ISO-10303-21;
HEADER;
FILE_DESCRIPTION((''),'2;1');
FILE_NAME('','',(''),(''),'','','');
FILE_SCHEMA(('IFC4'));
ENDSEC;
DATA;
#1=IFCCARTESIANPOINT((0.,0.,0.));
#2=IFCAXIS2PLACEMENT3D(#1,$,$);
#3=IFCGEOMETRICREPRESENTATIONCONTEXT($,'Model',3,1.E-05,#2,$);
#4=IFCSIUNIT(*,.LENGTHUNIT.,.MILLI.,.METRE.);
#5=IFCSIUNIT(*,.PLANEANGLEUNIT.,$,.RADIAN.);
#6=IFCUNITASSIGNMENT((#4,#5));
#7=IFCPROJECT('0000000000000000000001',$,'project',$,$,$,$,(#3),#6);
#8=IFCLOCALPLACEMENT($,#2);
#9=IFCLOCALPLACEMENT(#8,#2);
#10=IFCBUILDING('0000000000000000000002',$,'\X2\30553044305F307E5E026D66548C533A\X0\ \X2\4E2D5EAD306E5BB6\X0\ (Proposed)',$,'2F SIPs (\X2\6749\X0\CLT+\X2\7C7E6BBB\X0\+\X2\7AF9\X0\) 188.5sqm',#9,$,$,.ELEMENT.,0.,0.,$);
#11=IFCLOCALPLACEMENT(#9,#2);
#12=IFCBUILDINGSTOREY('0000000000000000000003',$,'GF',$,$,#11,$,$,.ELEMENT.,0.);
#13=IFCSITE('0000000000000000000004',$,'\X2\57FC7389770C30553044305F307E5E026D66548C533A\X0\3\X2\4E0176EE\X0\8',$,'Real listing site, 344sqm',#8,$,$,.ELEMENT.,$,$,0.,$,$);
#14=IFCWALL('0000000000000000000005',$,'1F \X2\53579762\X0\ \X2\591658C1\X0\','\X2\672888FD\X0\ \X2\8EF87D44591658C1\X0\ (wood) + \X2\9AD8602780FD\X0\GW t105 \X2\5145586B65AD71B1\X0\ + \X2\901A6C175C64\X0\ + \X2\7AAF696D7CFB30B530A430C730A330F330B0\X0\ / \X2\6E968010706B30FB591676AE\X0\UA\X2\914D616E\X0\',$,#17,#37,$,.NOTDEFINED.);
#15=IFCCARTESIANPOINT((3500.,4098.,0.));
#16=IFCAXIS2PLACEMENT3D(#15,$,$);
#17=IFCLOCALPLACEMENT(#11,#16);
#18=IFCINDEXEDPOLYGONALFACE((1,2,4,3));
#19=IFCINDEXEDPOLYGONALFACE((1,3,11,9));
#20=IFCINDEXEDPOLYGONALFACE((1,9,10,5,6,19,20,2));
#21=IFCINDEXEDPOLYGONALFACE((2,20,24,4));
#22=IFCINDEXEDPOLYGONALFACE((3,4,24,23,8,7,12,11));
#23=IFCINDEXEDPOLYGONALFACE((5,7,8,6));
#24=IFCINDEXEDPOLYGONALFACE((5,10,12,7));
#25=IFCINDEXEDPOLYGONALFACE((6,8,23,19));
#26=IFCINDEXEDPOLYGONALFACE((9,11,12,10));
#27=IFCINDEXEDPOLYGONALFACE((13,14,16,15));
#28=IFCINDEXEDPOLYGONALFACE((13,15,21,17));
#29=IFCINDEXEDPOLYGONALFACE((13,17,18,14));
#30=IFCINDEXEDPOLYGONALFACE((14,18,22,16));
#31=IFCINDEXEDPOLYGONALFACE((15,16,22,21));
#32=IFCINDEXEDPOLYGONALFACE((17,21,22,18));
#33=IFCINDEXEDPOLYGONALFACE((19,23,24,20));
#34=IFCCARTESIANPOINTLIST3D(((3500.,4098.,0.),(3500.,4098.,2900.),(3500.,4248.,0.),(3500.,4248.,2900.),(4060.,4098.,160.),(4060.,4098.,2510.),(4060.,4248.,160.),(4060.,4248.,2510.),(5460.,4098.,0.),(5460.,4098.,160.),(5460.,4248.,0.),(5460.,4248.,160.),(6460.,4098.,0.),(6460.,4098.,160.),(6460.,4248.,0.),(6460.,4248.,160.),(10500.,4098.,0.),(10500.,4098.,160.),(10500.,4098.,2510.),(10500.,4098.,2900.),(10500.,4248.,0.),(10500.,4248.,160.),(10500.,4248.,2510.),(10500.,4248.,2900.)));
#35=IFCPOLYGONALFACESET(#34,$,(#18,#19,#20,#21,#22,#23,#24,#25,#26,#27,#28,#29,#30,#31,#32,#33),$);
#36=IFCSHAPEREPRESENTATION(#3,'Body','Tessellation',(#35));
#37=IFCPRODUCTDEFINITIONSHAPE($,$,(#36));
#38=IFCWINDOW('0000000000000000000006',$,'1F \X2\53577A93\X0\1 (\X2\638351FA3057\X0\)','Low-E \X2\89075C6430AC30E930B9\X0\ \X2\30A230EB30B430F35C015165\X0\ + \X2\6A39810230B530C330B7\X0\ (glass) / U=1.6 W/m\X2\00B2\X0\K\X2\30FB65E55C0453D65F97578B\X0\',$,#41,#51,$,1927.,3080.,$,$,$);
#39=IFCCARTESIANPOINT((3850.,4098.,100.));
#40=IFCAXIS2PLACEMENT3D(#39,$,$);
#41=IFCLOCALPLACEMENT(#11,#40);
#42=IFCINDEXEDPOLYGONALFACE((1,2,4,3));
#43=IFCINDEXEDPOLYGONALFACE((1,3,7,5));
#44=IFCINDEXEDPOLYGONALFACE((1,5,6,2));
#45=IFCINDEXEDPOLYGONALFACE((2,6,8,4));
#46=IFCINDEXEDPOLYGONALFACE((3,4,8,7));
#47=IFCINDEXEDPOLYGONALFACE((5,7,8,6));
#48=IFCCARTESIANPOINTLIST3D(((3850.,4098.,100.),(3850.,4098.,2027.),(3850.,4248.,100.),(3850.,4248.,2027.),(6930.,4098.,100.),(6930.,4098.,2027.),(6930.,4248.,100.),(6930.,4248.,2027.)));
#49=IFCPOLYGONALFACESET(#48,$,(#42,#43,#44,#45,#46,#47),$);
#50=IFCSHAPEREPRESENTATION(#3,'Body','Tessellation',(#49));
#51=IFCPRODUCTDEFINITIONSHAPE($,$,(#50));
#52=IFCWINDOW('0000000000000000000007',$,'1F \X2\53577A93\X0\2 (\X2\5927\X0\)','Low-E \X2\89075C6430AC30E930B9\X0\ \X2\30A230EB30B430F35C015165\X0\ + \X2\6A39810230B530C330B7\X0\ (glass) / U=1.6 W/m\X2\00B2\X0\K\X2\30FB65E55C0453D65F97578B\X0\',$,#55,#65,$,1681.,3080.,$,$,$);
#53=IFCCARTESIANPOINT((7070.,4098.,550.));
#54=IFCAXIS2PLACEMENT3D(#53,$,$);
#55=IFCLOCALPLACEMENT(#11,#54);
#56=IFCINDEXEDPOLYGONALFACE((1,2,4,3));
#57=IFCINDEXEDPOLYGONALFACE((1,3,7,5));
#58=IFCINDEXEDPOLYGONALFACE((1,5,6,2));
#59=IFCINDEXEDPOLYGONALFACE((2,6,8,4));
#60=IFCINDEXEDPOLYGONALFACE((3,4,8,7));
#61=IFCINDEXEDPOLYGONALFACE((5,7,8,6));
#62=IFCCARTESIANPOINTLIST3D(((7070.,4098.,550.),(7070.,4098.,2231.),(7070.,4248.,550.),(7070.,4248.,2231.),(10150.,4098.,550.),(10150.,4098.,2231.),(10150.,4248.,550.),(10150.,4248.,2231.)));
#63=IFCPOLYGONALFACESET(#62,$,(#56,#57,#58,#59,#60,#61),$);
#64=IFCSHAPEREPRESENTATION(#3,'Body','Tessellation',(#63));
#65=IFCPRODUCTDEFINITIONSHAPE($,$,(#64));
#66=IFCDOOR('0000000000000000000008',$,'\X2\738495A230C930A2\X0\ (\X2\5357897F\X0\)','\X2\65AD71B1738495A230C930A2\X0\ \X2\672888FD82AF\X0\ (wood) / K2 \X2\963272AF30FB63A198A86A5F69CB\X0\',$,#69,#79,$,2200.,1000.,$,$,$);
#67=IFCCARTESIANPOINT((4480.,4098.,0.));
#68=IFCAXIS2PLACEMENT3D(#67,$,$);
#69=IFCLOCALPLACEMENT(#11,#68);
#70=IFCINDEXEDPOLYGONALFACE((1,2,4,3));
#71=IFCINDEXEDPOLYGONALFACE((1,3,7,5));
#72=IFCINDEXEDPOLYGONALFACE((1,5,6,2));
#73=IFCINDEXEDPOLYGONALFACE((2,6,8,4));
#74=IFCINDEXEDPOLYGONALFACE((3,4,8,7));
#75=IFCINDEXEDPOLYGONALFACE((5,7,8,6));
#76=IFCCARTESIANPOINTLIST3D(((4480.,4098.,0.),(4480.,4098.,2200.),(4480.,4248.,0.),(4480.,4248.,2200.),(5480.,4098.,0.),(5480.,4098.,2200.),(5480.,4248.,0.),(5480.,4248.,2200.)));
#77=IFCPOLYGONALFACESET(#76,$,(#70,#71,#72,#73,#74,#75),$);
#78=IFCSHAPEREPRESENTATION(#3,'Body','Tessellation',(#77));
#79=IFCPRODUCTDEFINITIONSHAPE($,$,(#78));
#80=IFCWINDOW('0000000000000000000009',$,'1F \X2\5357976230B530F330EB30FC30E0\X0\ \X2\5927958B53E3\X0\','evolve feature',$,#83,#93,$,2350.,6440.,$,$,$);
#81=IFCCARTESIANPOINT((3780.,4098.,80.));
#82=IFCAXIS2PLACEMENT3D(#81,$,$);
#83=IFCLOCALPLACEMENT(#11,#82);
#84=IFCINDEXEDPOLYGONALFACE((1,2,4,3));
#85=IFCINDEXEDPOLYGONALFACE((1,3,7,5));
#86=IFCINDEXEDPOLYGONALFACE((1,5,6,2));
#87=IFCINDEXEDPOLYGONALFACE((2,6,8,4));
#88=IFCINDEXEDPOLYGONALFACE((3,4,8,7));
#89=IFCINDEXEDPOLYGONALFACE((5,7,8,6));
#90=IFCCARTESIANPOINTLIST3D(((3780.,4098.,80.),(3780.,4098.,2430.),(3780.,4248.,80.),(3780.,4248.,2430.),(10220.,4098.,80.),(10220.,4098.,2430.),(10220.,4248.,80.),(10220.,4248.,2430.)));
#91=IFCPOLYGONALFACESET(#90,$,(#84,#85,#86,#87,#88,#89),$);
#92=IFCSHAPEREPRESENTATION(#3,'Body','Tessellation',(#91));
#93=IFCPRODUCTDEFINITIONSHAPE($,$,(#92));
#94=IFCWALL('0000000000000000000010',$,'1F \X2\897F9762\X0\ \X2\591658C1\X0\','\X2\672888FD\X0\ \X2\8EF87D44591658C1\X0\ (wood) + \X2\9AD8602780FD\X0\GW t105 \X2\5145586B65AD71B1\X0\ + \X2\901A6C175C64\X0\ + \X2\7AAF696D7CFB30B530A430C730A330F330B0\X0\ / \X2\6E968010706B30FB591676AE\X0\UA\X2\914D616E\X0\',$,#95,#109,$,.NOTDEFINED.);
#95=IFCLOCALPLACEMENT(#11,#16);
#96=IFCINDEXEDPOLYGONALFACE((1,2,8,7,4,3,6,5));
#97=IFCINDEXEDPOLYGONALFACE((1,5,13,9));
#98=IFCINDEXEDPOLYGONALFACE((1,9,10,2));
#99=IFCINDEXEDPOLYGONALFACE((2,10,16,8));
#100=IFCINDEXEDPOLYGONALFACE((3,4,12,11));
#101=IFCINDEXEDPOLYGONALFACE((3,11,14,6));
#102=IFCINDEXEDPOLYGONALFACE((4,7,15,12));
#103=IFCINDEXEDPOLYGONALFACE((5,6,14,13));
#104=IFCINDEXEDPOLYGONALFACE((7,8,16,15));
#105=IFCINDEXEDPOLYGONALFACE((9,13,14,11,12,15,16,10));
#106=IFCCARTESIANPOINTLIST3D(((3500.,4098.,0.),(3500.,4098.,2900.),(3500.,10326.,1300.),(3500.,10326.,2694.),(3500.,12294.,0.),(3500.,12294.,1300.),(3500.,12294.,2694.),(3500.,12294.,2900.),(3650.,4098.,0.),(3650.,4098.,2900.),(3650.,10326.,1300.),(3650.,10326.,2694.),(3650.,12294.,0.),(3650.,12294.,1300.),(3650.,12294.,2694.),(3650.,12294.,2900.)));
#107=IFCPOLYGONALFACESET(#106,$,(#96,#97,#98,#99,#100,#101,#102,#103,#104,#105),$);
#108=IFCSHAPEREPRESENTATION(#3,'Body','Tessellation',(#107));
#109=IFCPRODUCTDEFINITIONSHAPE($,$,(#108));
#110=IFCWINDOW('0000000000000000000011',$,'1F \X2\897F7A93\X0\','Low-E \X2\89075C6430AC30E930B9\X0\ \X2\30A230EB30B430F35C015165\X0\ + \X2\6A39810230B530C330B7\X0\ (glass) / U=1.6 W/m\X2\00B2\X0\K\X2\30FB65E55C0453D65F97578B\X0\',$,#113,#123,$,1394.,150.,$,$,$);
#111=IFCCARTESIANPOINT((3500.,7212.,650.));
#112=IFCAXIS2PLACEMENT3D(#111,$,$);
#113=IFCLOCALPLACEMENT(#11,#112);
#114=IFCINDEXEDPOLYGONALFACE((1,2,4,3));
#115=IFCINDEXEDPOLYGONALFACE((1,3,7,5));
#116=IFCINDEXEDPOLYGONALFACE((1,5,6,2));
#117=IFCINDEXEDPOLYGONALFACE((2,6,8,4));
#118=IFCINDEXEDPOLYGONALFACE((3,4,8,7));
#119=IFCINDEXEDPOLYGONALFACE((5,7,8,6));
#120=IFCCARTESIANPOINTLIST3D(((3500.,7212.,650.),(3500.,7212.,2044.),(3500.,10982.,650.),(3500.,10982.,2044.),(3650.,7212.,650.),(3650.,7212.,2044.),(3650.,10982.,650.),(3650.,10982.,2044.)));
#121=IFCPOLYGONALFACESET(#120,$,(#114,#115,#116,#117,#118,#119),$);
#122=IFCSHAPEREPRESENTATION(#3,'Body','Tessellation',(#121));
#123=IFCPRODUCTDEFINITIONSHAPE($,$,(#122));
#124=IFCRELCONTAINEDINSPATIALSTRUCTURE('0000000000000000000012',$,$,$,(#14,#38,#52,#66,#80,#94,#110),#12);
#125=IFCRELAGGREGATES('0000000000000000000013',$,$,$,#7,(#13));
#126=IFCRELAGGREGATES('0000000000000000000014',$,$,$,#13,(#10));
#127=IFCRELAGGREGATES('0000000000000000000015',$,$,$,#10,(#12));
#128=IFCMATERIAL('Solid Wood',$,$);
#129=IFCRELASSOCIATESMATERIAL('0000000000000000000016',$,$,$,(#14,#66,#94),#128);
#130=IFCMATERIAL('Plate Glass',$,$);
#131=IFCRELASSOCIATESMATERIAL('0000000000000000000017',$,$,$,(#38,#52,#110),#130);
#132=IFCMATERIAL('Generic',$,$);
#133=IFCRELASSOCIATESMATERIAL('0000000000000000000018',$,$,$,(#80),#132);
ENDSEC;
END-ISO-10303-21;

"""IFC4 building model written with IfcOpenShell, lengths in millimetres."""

from ifc_helpers import new_model, si_unit, frame, frame_2d, origin, place, context, project, spatial, rectangle, extrude, material, element, fill, save


model = new_model("IFC4")

# Units and contexts
model_context = context("Model", 3, precision=1e-05, world=origin())
ifc_project = project(units=[si_unit("LENGTHUNIT", "METRE", prefix="MILLI"), si_unit("PLANEANGLEUNIT", "RADIAN")], contexts=[model_context])

# Site, building, storey
site_placement = place(None, origin())
site = spatial("IfcSite", under=ifc_project, at=site_placement, Name="埼玉県さいたま市浦和区3丁目8", ObjectType="Real listing site, 344sqm", CompositionType="ELEMENT", RefElevation=0.0)
building_placement = place(site_placement, origin())
building = spatial("IfcBuilding", under=site, at=building_placement, Name="さいたま市浦和区 中庭の家 (Proposed)", ObjectType="2F SIPs (杉CLT+籾殻+竹) 188.5sqm", CompositionType="ELEMENT", ElevationOfRefHeight=0.0, ElevationOfTerrain=0.0)
storey_placement = place(building_placement, origin())
storey = spatial("IfcBuildingStorey", under=building, at=storey_placement, Name="GF", CompositionType="ELEMENT", Elevation=0.0)

# Shared definitions
ifc_material_1 = material(Name="Solid Wood")
ifc_material_2 = material(Name="Generic")

# Wall, openings, windows, door
wall_1_placement = place(storey_placement, frame((3500.0, 4098.0, 0.0)))
wall_1 = element("IfcWall", 1, at=wall_1_placement, inside=storey, material=ifc_material_1, Name="1F 南面 外壁", Description="木製 軸組外壁 (wood) + 高性能GW t105 充填断熱 + 通気層 + 窯業系サイディング / 準耐火・外皮UA配慮", PredefinedType="NOTDEFINED", context=model_context, shape_type="SweptSolid", body=[
    extrude(rectangle(XDim=7000.0, YDim=150.0, at=frame_2d((3500.0, 75.0))), frame((3500.0, 4098.0, 0.0)), (0.0, 0.0, 1.0), 2900.0),
])
opening_1_placement = place(storey_placement, frame((3850.0, 4098.0, 100.0)))
opening_1 = element("IfcOpeningElement", 2, at=opening_1_placement, cuts=wall_1, PredefinedType="NOTDEFINED", context=model_context, shape_type="SweptSolid", body=[
    extrude(rectangle(XDim=3080.0, YDim=150.0, at=frame_2d((1540.0, 75.0))), frame((3850.0, 4098.0, 100.0)), (0.0, 0.0, 1.0), 1927.0),
])
opening_2_placement = place(storey_placement, frame((7070.0, 4098.0, 550.0)))
opening_2 = element("IfcOpeningElement", 3, at=opening_2_placement, cuts=wall_1, PredefinedType="NOTDEFINED", context=model_context, shape_type="SweptSolid", body=[
    extrude(rectangle(XDim=3080.0, YDim=150.0, at=frame_2d((1540.0, 75.0))), frame((7070.0, 4098.0, 550.0)), (0.0, 0.0, 1.0), 1681.0),
])
opening_3_placement = place(storey_placement, frame((4480.0, 4098.0, 0.0)))
opening_3 = element("IfcOpeningElement", 4, at=opening_3_placement, cuts=wall_1, PredefinedType="NOTDEFINED", context=model_context, shape_type="SweptSolid", body=[
    extrude(rectangle(XDim=1000.0, YDim=150.0, at=frame_2d((500.0, 75.0))), frame((4480.0, 4098.0, 0.0)), (0.0, 0.0, 1.0), 2200.0),
])
opening_4_placement = place(storey_placement, frame((3780.0, 4098.0, 80.0)))
opening_4 = element("IfcOpeningElement", 5, at=opening_4_placement, cuts=wall_1, PredefinedType="NOTDEFINED", context=model_context, shape_type="SweptSolid", body=[
    extrude(rectangle(XDim=6440.0, YDim=150.0, at=frame_2d((3220.0, 75.0))), frame((3780.0, 4098.0, 80.0)), (0.0, 0.0, 1.0), 2350.0),
])
ifc_material_3 = material(Name="Plate Glass")
window_1_placement = place(storey_placement, frame((3850.0, 4098.0, 100.0)))
window_1 = element("IfcWindow", 6, at=window_1_placement, inside=storey, material=ifc_material_3, Name="1F 南窓1 (掃出し)", Description="Low-E 複層ガラス アルゴン封入 + 樹脂サッシ (glass) / U=1.6 W/m²K・日射取得型", OverallHeight=1927.0, OverallWidth=3080.0, context=model_context, shape_type="SweptSolid", body=[
    extrude(rectangle(XDim=3080.0, YDim=150.0, at=frame_2d((1540.0, 75.0))), frame((3850.0, 4098.0, 100.0)), (0.0, 0.0, 1.0), 1927.0),
])
fill(opening_1, window_1)
window_2_placement = place(storey_placement, frame((7070.0, 4098.0, 550.0)))
window_2 = element("IfcWindow", 7, at=window_2_placement, inside=storey, material=ifc_material_3, Name="1F 南窓2 (大)", Description="Low-E 複層ガラス アルゴン封入 + 樹脂サッシ (glass) / U=1.6 W/m²K・日射取得型", OverallHeight=1681.0, OverallWidth=3080.0, context=model_context, shape_type="SweptSolid", body=[
    extrude(rectangle(XDim=3080.0, YDim=150.0, at=frame_2d((1540.0, 75.0))), frame((7070.0, 4098.0, 550.0)), (0.0, 0.0, 1.0), 1681.0),
])
fill(opening_2, window_2)
door_placement = place(storey_placement, frame((4480.0, 4098.0, 0.0)))
door = element("IfcDoor", 8, at=door_placement, inside=storey, material=ifc_material_1, Name="玄関ドア (南西)", Description="断熱玄関ドア 木製芯 (wood) / K2 防犯・採風機構", OverallHeight=2200.0, OverallWidth=1000.0, context=model_context, shape_type="SweptSolid", body=[
    extrude(rectangle(XDim=1000.0, YDim=150.0, at=frame_2d((500.0, 75.0))), frame((4480.0, 4098.0, 0.0)), (0.0, 0.0, 1.0), 2200.0),
])
fill(opening_3, door)
window_3_placement = place(storey_placement, frame((3780.0, 4098.0, 80.0)))
window_3 = element("IfcWindow", 9, at=window_3_placement, inside=storey, material=ifc_material_2, Name="1F 南面サンルーム 大開口", Description="evolve feature", OverallHeight=2350.0, OverallWidth=6440.0, context=model_context, shape_type="SweptSolid", body=[
    extrude(rectangle(XDim=6440.0, YDim=150.0, at=frame_2d((3220.0, 75.0))), frame((3780.0, 4098.0, 80.0)), (0.0, 0.0, 1.0), 2350.0),
])
fill(opening_4, window_3)

# Wall, opening, window
wall_2_placement = place(storey_placement, frame((3500.0, 4098.0, 0.0)))
wall_2 = element("IfcWall", 10, at=wall_2_placement, inside=storey, material=ifc_material_1, Name="1F 西面 外壁", Description="木製 軸組外壁 (wood) + 高性能GW t105 充填断熱 + 通気層 + 窯業系サイディング / 準耐火・外皮UA配慮", PredefinedType="NOTDEFINED", context=model_context, shape_type="SweptSolid", body=[
    extrude(rectangle(XDim=150.0, YDim=8196.0, at=frame_2d((75.0, 4098.0))), frame((3500.0, 4098.0, 0.0)), (0.0, 0.0, 1.0), 2900.0),
])
opening_5_placement = place(storey_placement, frame((3500.0, 7212.0, 650.0)))
opening_5 = element("IfcOpeningElement", 11, at=opening_5_placement, cuts=wall_2, PredefinedType="NOTDEFINED", context=model_context, shape_type="SweptSolid", body=[
    extrude(rectangle(XDim=150.0, YDim=3770.0, at=frame_2d((75.0, 1885.0))), frame((3500.0, 7212.0, 650.0)), (0.0, 0.0, 1.0), 1394.0),
])
window_4_placement = place(storey_placement, frame((3500.0, 7212.0, 650.0)))
window_4 = element("IfcWindow", 12, at=window_4_placement, inside=storey, material=ifc_material_3, Name="1F 西窓", Description="Low-E 複層ガラス アルゴン封入 + 樹脂サッシ (glass) / U=1.6 W/m²K・日射取得型", OverallHeight=1394.0, OverallWidth=150.0, context=model_context, shape_type="SweptSolid", body=[
    extrude(rectangle(XDim=150.0, YDim=3770.0, at=frame_2d((75.0, 1885.0))), frame((3500.0, 7212.0, 650.0)), (0.0, 0.0, 1.0), 1394.0),
])
fill(opening_5, window_4)

save(model, "model.ifc")
